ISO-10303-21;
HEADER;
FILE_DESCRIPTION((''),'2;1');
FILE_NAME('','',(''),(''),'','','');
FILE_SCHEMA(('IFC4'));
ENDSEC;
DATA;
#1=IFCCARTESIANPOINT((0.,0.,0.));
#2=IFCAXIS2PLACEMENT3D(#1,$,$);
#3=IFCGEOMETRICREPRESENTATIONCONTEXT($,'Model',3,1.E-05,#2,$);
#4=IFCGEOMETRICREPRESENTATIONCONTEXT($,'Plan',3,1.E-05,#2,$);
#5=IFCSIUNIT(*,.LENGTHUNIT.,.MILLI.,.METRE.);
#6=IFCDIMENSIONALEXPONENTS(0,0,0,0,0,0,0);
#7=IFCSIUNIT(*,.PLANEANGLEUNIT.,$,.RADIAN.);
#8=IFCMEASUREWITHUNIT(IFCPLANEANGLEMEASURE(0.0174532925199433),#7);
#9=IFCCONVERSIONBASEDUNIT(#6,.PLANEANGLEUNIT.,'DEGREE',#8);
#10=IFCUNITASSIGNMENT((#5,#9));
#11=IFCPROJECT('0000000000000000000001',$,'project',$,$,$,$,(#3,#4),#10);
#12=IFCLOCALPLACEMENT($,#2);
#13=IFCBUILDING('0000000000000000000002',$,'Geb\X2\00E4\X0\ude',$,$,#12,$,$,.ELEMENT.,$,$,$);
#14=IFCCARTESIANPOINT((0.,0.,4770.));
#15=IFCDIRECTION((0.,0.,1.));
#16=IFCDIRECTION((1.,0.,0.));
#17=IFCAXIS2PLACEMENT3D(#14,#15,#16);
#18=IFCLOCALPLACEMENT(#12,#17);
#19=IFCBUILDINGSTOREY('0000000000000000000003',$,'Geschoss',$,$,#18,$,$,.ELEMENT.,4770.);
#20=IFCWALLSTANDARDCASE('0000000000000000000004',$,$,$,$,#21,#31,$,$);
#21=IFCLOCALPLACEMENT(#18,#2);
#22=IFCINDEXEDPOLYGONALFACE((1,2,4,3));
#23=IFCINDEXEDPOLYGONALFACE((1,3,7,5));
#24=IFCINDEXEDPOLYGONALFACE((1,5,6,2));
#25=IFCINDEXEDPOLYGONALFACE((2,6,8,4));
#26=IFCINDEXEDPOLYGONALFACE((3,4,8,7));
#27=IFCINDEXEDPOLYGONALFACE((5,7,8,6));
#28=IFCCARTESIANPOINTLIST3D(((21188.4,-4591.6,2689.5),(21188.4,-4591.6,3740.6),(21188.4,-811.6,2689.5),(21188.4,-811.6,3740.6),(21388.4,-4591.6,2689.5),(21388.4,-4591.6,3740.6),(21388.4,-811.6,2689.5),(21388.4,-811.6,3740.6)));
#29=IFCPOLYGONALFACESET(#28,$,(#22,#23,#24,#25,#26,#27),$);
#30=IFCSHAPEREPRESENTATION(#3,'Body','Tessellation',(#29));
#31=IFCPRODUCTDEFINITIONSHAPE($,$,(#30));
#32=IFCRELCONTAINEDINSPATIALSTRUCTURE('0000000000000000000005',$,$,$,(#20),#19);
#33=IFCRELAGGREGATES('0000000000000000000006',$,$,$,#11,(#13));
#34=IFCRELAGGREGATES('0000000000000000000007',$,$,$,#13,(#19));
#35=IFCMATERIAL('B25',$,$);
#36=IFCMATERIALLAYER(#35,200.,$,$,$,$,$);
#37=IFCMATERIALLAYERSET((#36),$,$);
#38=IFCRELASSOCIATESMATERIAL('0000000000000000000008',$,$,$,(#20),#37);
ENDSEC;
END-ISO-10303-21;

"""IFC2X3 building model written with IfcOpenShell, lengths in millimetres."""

from ifc_helpers import new_model, entity, si_unit, converted_unit, frame, frame_2d, origin, origin_with_axes, place, context, project, spatial, rectangle, extrude, material, layer, layer_set, layer_usage, element, save


model = new_model("IFC2X3")

# Units and contexts
model_context = context("Model", 3, precision=1e-05, world=origin())
plan_context = context("Plan", 3, precision=1e-05, world=origin())
ifc_project = project(units=[si_unit("LENGTHUNIT", "METRE", prefix="MILLI"), converted_unit("PLANEANGLEUNIT", "DEGREE", entity("IfcPlaneAngleMeasure", 0.0174532925199433), si_unit("PLANEANGLEUNIT", "RADIAN"), dimensions=[0, 0, 0, 0, 0, 0, 0])], contexts=[model_context, plan_context])

# Building, storey
building_placement = place(None, origin())
building = spatial("IfcBuilding", under=ifc_project, at=building_placement, Name="Gebäude", CompositionType="ELEMENT")
storey_placement = place(building_placement, frame((0.0, 0.0, 4770.0), z_axis=(0.0, 0.0, 1.0), x_axis=(1.0, 0.0, 0.0)))
storey = spatial("IfcBuildingStorey", under=building, at=storey_placement, Name="Geschoss", CompositionType="ELEMENT", Elevation=4770.0)

# Wall
ifc_material_1 = material(Name="B25")
ifc_layer_1 = layer(ifc_material_1, 200.0)
ifc_layer_set_1 = layer_set([ifc_layer_1])
ifc_layer_usage_1 = layer_usage(ifc_layer_set_1, "AXIS2", "POSITIVE", 0.0)
wall_1_placement = place(storey_placement, frame((21188.4, -811.6, 2689.5), z_axis=(0.0, 0.0, 1.0), x_axis=(0.0, -1.0, 0.0)))
element("IfcWallStandardCase", 1, at=wall_1_placement, inside=storey, material=ifc_layer_usage_1, context=model_context, shape_type="SweptSolid", body=[
    extrude(rectangle(XDim=3780.0, YDim=200.0, at=frame_2d((1890.0, 100.0), x_axis=(1.0, 0.0))), origin_with_axes(), (0.0, 0.0, 1.0), 1051.1),
])

save(model, "model.ifc")
